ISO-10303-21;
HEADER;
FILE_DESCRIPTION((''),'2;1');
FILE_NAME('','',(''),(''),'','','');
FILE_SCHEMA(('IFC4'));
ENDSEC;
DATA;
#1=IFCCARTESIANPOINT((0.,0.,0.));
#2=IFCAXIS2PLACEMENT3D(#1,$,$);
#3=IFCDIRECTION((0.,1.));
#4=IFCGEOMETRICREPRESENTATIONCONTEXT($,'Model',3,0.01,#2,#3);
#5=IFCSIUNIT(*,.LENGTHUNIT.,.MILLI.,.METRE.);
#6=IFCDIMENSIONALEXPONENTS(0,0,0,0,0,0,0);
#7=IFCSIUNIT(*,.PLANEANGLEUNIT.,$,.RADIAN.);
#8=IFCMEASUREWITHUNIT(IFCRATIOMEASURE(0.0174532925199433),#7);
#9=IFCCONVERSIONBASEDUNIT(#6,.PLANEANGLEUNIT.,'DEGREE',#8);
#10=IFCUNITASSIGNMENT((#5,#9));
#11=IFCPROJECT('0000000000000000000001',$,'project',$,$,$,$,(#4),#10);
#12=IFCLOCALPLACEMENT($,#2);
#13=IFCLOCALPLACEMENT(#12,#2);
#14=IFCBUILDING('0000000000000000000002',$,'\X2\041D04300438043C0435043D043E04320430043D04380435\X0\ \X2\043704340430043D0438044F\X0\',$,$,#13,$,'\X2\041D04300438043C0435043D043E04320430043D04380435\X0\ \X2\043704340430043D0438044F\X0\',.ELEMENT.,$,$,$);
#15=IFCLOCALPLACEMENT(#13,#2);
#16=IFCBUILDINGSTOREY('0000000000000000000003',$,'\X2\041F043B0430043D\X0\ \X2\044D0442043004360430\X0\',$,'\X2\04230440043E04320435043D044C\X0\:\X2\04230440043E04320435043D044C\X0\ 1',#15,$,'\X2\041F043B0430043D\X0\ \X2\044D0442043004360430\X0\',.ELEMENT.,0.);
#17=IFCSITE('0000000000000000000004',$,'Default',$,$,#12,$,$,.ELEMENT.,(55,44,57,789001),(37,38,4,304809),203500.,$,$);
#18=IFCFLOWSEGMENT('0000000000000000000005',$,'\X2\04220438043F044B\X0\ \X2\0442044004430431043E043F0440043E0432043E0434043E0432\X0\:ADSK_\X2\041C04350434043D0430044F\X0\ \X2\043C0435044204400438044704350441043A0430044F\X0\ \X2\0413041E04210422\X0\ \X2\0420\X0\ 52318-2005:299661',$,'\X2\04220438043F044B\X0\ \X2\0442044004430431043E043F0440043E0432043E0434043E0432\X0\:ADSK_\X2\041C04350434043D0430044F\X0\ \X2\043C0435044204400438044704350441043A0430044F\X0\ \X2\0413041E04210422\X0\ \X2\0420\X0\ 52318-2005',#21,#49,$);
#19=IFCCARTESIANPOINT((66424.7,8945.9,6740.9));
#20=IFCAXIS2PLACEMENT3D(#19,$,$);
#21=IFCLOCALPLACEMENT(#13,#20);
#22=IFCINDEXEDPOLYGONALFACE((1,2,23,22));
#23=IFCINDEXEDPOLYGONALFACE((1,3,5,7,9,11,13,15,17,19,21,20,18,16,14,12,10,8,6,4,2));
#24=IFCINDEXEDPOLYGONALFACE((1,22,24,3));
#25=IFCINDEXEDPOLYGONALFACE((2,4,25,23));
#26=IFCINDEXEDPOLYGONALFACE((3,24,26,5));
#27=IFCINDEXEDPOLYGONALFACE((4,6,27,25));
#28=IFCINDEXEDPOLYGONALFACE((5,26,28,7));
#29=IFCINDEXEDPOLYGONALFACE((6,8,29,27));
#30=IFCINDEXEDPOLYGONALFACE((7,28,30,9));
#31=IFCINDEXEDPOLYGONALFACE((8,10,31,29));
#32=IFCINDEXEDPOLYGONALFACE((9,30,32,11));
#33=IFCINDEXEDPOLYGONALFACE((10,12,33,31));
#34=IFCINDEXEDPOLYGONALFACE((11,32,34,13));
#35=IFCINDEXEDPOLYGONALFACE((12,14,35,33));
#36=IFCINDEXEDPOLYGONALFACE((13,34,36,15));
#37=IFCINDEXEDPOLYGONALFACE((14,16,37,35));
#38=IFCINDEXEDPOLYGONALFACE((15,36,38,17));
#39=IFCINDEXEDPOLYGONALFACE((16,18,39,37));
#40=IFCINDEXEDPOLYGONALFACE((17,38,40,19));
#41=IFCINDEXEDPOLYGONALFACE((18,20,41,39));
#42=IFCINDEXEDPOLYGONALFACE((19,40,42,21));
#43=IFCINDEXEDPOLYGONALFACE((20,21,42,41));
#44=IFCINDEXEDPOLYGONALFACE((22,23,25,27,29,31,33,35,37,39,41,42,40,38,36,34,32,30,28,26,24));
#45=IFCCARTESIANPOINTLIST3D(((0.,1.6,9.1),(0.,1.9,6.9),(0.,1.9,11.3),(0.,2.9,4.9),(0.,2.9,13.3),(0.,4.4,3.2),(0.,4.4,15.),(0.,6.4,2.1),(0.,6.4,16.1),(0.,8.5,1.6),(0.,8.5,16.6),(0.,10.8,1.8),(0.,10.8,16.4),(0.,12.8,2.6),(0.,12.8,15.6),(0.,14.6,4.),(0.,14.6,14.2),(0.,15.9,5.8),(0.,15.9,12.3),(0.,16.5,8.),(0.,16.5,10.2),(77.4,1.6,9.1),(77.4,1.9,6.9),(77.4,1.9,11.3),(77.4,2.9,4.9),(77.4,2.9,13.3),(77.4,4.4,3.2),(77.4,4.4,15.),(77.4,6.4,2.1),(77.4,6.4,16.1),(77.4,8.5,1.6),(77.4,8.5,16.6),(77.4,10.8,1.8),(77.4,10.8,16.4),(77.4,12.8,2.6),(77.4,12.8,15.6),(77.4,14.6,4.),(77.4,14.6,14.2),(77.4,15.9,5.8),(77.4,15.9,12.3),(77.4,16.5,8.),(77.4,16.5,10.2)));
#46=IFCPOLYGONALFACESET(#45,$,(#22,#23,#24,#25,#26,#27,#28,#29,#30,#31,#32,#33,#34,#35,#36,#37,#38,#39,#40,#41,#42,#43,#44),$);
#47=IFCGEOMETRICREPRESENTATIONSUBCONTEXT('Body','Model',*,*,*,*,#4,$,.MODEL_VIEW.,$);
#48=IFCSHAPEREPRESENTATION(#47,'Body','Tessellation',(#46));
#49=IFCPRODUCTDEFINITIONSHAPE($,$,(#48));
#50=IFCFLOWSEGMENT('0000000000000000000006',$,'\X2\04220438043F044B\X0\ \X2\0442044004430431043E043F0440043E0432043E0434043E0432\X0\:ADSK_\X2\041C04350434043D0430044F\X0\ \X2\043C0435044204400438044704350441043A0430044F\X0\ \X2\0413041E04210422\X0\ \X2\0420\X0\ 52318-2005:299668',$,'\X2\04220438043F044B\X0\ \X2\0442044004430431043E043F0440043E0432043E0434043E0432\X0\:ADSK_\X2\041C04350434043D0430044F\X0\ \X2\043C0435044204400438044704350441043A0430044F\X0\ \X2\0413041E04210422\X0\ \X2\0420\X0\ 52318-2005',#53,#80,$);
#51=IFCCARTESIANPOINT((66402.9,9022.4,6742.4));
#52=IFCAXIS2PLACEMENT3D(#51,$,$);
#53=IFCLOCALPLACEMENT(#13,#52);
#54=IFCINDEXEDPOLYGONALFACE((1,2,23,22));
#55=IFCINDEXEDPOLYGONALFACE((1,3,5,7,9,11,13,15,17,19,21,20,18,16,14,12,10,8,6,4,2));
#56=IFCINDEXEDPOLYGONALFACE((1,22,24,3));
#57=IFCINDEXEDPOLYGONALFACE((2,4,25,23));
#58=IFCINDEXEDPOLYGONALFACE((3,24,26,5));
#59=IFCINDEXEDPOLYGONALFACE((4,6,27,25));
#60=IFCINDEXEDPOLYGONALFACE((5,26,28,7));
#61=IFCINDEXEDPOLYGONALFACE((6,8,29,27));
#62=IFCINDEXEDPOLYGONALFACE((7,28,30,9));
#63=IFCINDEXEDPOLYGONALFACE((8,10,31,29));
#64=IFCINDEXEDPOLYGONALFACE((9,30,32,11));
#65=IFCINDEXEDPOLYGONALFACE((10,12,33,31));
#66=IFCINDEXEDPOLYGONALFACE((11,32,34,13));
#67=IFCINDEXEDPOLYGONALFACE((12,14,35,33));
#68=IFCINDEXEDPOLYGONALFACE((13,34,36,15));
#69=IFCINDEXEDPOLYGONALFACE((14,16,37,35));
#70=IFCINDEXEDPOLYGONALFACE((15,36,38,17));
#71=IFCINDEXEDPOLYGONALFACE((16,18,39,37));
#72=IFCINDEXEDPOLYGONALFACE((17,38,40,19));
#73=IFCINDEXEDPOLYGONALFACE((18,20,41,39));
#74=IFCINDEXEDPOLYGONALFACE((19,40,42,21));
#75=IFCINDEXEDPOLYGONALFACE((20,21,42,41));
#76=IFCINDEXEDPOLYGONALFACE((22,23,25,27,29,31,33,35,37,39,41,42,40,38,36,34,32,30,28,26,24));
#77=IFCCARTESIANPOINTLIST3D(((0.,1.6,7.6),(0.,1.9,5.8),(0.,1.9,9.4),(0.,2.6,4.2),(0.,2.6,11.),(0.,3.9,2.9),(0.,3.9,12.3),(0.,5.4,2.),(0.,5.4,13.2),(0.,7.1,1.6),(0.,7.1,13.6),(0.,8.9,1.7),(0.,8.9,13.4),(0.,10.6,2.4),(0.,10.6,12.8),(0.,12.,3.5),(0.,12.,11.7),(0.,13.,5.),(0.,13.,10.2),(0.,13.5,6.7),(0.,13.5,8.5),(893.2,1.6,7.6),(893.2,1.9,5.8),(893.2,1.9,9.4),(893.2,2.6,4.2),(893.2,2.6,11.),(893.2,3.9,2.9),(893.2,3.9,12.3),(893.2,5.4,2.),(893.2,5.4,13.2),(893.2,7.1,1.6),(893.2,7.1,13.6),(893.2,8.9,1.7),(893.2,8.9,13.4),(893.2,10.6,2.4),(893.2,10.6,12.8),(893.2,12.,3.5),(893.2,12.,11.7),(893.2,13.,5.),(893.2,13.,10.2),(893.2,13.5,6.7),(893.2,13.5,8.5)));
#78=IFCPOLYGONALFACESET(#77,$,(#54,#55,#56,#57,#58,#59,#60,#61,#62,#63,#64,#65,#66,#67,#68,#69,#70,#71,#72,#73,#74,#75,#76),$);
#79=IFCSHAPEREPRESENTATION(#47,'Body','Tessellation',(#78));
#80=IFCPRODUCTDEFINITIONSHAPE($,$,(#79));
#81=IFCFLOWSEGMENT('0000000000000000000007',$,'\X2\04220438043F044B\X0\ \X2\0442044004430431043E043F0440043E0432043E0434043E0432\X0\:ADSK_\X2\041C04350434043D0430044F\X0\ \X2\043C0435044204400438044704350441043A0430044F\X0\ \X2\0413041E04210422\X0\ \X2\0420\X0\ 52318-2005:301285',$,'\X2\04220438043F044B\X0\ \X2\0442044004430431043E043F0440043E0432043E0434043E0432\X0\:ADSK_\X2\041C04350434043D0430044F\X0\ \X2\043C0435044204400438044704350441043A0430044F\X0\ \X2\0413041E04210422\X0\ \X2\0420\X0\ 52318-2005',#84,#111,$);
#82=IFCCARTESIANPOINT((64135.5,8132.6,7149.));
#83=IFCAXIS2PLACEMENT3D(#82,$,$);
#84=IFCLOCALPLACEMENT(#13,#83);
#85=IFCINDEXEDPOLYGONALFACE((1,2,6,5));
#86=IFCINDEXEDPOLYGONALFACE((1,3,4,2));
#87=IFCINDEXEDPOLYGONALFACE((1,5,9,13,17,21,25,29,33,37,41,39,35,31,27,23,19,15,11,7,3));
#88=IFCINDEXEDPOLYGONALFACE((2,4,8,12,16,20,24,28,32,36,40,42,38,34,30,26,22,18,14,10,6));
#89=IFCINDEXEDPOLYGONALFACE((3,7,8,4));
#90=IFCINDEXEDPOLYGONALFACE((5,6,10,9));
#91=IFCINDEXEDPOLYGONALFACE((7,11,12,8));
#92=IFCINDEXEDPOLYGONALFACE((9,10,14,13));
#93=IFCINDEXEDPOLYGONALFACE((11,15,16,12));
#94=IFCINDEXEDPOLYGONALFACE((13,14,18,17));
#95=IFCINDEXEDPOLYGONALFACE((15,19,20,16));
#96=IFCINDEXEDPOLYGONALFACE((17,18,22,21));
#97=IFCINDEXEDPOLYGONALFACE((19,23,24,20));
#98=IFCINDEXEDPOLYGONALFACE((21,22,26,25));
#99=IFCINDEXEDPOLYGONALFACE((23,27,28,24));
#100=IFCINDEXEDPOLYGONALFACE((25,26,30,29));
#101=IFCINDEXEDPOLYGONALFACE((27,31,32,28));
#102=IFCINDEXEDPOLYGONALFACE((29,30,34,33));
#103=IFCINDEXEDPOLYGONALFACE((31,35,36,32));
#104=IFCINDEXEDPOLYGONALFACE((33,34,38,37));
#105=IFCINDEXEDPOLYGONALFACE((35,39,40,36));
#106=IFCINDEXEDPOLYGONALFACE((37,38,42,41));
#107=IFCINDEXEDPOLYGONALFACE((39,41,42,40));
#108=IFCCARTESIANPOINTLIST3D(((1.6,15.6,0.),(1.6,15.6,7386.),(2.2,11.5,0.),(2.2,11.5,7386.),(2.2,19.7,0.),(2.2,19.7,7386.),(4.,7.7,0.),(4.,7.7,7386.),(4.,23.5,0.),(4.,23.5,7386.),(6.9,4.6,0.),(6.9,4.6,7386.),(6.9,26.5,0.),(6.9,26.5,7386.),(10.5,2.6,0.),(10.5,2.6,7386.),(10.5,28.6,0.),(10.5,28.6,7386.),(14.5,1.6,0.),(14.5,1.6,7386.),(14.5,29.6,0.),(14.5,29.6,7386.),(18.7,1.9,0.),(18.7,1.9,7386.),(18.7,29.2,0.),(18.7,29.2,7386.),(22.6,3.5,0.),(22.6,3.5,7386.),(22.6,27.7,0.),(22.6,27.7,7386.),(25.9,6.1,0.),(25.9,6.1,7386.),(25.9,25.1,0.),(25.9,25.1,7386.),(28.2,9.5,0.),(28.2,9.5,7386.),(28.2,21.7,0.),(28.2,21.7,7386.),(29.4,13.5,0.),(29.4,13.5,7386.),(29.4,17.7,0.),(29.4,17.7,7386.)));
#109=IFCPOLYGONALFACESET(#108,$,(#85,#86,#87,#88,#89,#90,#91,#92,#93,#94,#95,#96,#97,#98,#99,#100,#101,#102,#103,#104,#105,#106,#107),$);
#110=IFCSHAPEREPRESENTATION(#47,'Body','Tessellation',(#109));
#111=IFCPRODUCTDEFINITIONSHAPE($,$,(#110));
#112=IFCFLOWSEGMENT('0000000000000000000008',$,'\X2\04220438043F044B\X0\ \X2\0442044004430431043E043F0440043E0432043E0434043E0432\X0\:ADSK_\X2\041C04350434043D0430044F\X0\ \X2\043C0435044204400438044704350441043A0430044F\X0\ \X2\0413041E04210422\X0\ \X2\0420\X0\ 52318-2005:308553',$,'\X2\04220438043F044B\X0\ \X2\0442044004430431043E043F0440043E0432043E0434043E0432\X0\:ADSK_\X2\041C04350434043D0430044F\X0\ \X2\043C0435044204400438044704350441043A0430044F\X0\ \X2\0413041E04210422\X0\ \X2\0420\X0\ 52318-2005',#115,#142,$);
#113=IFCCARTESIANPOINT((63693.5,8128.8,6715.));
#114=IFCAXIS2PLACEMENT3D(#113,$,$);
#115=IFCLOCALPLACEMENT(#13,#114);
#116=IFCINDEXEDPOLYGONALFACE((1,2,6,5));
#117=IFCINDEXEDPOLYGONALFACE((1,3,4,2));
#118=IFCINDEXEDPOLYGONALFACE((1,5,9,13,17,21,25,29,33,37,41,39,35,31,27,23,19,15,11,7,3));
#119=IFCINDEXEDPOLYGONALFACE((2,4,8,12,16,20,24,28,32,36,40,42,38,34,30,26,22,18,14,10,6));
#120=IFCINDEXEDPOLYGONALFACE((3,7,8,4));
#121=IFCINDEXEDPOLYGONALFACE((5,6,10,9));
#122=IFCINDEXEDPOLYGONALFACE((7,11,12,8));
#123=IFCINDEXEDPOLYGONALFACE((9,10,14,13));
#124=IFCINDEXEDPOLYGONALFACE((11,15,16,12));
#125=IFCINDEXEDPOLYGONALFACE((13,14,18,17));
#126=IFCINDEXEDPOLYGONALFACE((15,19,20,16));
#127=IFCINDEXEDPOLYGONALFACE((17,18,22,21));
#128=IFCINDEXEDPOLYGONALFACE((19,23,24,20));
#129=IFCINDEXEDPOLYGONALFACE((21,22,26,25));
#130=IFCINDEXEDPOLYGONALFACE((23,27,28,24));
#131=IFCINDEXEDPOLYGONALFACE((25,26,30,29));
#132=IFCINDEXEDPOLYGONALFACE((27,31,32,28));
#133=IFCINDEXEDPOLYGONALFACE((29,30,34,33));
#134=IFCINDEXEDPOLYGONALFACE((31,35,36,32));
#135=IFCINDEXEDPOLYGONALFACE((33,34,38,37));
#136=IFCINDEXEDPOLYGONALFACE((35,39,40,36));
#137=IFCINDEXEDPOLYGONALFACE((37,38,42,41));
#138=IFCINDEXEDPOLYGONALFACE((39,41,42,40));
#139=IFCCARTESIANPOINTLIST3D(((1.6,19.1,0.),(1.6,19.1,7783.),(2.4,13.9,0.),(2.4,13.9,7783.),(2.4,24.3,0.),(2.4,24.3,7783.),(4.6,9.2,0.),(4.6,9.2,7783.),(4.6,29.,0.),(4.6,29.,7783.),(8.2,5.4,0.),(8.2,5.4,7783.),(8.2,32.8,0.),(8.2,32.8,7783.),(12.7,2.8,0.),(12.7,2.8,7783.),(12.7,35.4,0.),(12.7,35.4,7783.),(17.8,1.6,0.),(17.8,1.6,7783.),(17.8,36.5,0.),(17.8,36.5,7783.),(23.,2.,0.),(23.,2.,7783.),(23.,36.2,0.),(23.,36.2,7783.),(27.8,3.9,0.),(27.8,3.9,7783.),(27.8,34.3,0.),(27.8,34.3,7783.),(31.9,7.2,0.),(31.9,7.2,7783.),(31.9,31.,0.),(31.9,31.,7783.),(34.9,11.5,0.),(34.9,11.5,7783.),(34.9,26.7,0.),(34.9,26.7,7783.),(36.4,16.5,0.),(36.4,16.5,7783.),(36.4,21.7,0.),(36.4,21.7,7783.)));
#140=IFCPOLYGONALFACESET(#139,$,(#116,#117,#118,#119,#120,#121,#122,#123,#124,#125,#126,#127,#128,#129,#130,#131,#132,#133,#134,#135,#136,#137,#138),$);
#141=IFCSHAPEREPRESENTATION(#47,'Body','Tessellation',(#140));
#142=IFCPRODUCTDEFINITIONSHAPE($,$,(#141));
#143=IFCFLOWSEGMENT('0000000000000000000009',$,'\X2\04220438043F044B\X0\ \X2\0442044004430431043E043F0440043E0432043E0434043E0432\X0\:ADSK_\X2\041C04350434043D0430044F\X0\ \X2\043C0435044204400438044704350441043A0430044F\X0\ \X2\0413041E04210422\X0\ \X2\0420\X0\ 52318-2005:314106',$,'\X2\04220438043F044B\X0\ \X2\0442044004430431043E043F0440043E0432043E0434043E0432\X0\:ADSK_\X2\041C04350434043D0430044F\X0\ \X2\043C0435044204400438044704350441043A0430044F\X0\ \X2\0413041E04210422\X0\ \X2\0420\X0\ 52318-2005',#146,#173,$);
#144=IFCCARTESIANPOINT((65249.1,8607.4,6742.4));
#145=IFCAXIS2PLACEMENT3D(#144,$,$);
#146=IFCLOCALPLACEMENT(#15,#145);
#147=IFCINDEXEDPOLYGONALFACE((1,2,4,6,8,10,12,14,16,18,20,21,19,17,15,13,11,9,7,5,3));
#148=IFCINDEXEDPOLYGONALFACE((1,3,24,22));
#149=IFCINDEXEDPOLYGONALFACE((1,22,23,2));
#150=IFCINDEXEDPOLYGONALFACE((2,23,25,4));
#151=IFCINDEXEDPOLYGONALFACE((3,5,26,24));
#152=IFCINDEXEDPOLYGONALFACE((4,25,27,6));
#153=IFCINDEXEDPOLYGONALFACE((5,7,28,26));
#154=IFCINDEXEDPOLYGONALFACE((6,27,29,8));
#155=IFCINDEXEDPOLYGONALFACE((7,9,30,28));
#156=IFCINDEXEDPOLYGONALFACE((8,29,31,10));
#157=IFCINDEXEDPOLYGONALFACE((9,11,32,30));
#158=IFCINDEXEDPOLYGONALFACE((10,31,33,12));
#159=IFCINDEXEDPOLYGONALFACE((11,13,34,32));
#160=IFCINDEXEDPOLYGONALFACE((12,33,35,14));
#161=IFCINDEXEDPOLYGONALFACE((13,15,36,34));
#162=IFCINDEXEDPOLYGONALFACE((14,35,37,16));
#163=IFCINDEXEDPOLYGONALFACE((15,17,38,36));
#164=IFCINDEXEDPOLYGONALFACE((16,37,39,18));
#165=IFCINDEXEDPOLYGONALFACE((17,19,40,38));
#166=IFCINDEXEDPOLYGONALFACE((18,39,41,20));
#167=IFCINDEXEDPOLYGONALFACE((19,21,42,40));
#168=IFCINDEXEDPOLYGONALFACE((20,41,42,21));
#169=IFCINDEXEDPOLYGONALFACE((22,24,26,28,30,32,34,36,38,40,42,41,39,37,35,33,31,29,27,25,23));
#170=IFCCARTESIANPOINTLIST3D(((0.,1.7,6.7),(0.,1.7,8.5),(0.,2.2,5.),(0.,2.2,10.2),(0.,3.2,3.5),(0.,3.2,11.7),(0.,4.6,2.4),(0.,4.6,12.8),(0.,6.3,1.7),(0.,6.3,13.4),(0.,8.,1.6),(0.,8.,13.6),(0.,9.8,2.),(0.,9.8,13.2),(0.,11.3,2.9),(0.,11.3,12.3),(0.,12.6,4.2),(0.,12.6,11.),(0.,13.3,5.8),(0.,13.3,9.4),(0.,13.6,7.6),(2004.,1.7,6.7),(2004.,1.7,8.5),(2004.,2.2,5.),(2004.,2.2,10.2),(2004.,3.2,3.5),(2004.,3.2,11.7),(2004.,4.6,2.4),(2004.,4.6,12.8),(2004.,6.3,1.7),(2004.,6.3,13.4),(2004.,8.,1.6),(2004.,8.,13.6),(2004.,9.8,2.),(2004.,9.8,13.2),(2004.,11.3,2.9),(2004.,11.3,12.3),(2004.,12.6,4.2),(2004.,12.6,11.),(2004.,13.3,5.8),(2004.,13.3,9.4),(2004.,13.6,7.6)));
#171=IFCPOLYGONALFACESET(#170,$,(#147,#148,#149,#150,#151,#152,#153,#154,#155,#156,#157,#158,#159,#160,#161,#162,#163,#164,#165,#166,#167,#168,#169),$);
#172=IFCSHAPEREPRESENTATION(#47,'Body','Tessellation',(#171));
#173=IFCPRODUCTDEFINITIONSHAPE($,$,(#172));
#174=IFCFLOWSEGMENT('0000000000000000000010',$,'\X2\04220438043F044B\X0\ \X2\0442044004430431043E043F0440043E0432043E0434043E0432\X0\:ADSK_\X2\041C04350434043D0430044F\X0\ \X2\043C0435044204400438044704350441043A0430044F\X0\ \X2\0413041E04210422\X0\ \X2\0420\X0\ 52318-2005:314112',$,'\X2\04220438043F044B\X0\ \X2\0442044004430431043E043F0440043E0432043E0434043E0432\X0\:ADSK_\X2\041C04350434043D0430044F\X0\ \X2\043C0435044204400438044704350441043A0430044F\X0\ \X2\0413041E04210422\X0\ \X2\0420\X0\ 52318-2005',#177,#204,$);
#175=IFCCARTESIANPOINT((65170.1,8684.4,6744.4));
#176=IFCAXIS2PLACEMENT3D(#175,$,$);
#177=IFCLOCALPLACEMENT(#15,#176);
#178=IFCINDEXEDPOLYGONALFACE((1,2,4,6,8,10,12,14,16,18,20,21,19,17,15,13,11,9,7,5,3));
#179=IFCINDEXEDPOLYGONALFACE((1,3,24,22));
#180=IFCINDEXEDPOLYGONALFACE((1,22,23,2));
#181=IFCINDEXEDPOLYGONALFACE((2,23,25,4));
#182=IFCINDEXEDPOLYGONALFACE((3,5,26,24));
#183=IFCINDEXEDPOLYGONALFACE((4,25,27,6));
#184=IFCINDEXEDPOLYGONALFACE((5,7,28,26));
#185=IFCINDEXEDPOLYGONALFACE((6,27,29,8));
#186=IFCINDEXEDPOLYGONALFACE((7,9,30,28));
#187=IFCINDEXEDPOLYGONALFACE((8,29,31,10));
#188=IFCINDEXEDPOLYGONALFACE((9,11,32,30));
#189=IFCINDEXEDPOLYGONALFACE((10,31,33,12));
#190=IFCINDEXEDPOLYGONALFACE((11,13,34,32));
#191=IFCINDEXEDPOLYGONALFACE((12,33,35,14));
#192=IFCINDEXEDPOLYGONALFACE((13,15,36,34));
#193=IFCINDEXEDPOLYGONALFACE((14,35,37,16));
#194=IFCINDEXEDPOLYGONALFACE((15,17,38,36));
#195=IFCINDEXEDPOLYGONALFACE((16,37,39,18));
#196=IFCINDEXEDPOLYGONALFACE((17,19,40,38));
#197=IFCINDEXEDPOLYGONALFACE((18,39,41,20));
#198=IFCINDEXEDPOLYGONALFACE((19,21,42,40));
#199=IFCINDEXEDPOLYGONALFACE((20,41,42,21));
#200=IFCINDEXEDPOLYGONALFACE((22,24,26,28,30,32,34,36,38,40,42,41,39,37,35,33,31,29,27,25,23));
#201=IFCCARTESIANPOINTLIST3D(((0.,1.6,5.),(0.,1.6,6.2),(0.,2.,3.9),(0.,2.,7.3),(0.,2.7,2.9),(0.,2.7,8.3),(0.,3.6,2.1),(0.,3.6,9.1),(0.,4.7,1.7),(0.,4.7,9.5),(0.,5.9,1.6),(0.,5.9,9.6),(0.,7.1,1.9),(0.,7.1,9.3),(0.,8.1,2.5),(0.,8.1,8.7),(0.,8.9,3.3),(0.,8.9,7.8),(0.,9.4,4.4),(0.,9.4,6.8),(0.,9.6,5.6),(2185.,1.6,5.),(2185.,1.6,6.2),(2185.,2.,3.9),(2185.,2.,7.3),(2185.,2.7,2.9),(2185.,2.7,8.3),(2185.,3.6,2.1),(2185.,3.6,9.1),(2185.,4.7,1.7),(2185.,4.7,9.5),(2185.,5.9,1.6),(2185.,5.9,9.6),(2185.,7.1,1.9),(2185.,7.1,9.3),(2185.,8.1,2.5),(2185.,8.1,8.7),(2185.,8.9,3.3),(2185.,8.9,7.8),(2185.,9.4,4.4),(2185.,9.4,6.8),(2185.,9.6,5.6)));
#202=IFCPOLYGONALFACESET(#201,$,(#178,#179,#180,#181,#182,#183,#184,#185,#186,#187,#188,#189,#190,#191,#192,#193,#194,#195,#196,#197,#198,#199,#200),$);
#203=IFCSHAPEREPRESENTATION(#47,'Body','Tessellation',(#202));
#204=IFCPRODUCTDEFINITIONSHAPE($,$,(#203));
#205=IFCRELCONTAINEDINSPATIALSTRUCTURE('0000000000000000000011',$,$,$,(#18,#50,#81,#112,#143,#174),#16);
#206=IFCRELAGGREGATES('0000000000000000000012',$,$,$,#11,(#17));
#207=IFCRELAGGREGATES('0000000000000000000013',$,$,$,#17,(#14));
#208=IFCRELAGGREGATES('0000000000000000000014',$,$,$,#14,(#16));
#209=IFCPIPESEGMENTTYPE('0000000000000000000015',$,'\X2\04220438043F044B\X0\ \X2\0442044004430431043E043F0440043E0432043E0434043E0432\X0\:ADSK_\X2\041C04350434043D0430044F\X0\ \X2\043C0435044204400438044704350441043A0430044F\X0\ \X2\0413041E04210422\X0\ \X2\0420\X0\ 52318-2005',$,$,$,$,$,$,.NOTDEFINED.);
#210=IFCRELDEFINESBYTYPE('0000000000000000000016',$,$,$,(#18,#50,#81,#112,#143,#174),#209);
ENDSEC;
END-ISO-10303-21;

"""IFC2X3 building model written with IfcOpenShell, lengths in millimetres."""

from ifc_helpers import new_model, entity, si_unit, converted_unit, direction, frame, frame_2d, origin, origin_2d_with_axis, place, context, subcontext, project, spatial, circle, extrude, type_object, element, save


model = new_model("IFC2X3")

# Units and contexts
model_context = context("Model", 3, precision=0.01, world=origin(), true_north=direction((0.0, 1.0)))
body_context = subcontext(model_context, "Body", "Model", "MODEL_VIEW")
ifc_project = project(units=[si_unit("LENGTHUNIT", "METRE", prefix="MILLI"), converted_unit("PLANEANGLEUNIT", "DEGREE", entity("IfcRatioMeasure", 0.0174532925199433), si_unit("PLANEANGLEUNIT", "RADIAN"), dimensions=[0, 0, 0, 0, 0, 0, 0])], contexts=[model_context])

# Site, building, storey
site_placement = place(None, frame((0.0, 0.0, 0.0)))
site = spatial("IfcSite", under=ifc_project, at=site_placement, Name="Default", CompositionType="ELEMENT", RefLatitude=(55, 44, 57, 789001), RefLongitude=(37, 38, 4, 304809), RefElevation=203500.0)
building_placement = place(site_placement, origin())
building = spatial("IfcBuilding", under=site, at=building_placement, Name="Наименование здания", LongName="Наименование здания", CompositionType="ELEMENT")
storey_placement = place(building_placement, origin())
storey = spatial("IfcBuildingStorey", under=building, at=storey_placement, Name="План этажа", ObjectType="Уровень:Уровень 1", LongName="План этажа", CompositionType="ELEMENT", Elevation=0.0)

# Flow segments
pipe_segment_type = type_object("IfcPipeSegmentType", Name="Типы трубопроводов:ADSK_Медная метрическая ГОСТ Р 52318-2005", PredefinedType="NOTDEFINED")
flow_segment_1_placement = place(building_placement, frame((66424.7, 8945.9, 6740.9)))
element("IfcFlowSegment", 1, at=flow_segment_1_placement, inside=storey, type_object=pipe_segment_type, Name="Типы трубопроводов:ADSK_Медная метрическая ГОСТ Р 52318-2005:299661", ObjectType="Типы трубопроводов:ADSK_Медная метрическая ГОСТ Р 52318-2005", context=body_context, shape_type="SweptSolid", body=[
    extrude(circle(Radius=7.5, at=origin_2d_with_axis()), frame((0.0, 9.1, 9.1), z_axis=(1.0, 0.0, 0.0), x_axis=(0.0, -1.0, 0.0)), (0.0, 0.0, 1.0), 77.4),
])
flow_segment_2_placement = place(building_placement, frame((66402.9, 9022.4, 6742.4)))
element("IfcFlowSegment", 2, at=flow_segment_2_placement, inside=storey, type_object=pipe_segment_type, Name="Типы трубопроводов:ADSK_Медная метрическая ГОСТ Р 52318-2005:299668", ObjectType="Типы трубопроводов:ADSK_Медная метрическая ГОСТ Р 52318-2005", context=body_context, shape_type="SweptSolid", body=[
    extrude(circle(Radius=6.0, at=frame_2d((0.0, 0.0), x_axis=(1.0, 0.0))), frame((0.0, 7.6, 7.6), z_axis=(1.0, 0.0, 0.0), x_axis=(0.0, -1.0, 0.0)), (0.0, 0.0, 1.0), 893.2),
])
flow_segment_3_placement = place(building_placement, frame((64135.5, 8132.6, 7149.0)))
element("IfcFlowSegment", 3, at=flow_segment_3_placement, inside=storey, type_object=pipe_segment_type, Name="Типы трубопроводов:ADSK_Медная метрическая ГОСТ Р 52318-2005:301285", ObjectType="Типы трубопроводов:ADSK_Медная метрическая ГОСТ Р 52318-2005", context=body_context, shape_type="SweptSolid", body=[
    extrude(circle(Radius=14.0, at=origin_2d_with_axis()), frame((15.6, 15.6, 0.0), z_axis=(0.0, 0.0, 1.0), x_axis=(-1.0, 0.0, 0.0)), (0.0, 0.0, 1.0), 7386.0),
])
flow_segment_4_placement = place(building_placement, frame((63693.5, 8128.8, 6715.0)))
element("IfcFlowSegment", 4, at=flow_segment_4_placement, inside=storey, type_object=pipe_segment_type, Name="Типы трубопроводов:ADSK_Медная метрическая ГОСТ Р 52318-2005:308553", ObjectType="Типы трубопроводов:ADSK_Медная метрическая ГОСТ Р 52318-2005", context=body_context, shape_type="SweptSolid", body=[
    extrude(circle(Radius=17.5, at=origin_2d_with_axis()), frame((19.1, 19.1, 0.0), z_axis=(0.0, 0.0, 1.0), x_axis=(-1.0, 0.0, 0.0)), (0.0, 0.0, 1.0), 7783.0),
])
flow_segment_5_placement = place(storey_placement, frame((65249.1, 8607.4, 6742.4)))
element("IfcFlowSegment", 5, at=flow_segment_5_placement, inside=storey, type_object=pipe_segment_type, Name="Типы трубопроводов:ADSK_Медная метрическая ГОСТ Р 52318-2005:314106", ObjectType="Типы трубопроводов:ADSK_Медная метрическая ГОСТ Р 52318-2005", context=body_context, shape_type="SweptSolid", body=[
    extrude(circle(Radius=6.0, at=frame_2d((0.0, 0.0), x_axis=(1.0, 0.0))), frame((0.0, 7.6, 7.6), z_axis=(1.0, 0.0, 0.0), x_axis=(0.0, 1.0, 0.0)), (0.0, 0.0, 1.0), 2004.0),
])
flow_segment_6_placement = place(storey_placement, frame((65170.1, 8684.4, 6744.4)))
element("IfcFlowSegment", 6, at=flow_segment_6_placement, inside=storey, type_object=pipe_segment_type, Name="Типы трубопроводов:ADSK_Медная метрическая ГОСТ Р 52318-2005:314112", ObjectType="Типы трубопроводов:ADSK_Медная метрическая ГОСТ Р 52318-2005", context=body_context, shape_type="SweptSolid", body=[
    extrude(circle(Radius=4.0, at=frame_2d((0.0, 0.0), x_axis=(1.0, 0.0))), frame((0.0, 5.6, 5.6), z_axis=(1.0, 0.0, 0.0), x_axis=(0.0, 1.0, 0.0)), (0.0, 0.0, 1.0), 2185.0),
])

save(model, "model.ifc")
